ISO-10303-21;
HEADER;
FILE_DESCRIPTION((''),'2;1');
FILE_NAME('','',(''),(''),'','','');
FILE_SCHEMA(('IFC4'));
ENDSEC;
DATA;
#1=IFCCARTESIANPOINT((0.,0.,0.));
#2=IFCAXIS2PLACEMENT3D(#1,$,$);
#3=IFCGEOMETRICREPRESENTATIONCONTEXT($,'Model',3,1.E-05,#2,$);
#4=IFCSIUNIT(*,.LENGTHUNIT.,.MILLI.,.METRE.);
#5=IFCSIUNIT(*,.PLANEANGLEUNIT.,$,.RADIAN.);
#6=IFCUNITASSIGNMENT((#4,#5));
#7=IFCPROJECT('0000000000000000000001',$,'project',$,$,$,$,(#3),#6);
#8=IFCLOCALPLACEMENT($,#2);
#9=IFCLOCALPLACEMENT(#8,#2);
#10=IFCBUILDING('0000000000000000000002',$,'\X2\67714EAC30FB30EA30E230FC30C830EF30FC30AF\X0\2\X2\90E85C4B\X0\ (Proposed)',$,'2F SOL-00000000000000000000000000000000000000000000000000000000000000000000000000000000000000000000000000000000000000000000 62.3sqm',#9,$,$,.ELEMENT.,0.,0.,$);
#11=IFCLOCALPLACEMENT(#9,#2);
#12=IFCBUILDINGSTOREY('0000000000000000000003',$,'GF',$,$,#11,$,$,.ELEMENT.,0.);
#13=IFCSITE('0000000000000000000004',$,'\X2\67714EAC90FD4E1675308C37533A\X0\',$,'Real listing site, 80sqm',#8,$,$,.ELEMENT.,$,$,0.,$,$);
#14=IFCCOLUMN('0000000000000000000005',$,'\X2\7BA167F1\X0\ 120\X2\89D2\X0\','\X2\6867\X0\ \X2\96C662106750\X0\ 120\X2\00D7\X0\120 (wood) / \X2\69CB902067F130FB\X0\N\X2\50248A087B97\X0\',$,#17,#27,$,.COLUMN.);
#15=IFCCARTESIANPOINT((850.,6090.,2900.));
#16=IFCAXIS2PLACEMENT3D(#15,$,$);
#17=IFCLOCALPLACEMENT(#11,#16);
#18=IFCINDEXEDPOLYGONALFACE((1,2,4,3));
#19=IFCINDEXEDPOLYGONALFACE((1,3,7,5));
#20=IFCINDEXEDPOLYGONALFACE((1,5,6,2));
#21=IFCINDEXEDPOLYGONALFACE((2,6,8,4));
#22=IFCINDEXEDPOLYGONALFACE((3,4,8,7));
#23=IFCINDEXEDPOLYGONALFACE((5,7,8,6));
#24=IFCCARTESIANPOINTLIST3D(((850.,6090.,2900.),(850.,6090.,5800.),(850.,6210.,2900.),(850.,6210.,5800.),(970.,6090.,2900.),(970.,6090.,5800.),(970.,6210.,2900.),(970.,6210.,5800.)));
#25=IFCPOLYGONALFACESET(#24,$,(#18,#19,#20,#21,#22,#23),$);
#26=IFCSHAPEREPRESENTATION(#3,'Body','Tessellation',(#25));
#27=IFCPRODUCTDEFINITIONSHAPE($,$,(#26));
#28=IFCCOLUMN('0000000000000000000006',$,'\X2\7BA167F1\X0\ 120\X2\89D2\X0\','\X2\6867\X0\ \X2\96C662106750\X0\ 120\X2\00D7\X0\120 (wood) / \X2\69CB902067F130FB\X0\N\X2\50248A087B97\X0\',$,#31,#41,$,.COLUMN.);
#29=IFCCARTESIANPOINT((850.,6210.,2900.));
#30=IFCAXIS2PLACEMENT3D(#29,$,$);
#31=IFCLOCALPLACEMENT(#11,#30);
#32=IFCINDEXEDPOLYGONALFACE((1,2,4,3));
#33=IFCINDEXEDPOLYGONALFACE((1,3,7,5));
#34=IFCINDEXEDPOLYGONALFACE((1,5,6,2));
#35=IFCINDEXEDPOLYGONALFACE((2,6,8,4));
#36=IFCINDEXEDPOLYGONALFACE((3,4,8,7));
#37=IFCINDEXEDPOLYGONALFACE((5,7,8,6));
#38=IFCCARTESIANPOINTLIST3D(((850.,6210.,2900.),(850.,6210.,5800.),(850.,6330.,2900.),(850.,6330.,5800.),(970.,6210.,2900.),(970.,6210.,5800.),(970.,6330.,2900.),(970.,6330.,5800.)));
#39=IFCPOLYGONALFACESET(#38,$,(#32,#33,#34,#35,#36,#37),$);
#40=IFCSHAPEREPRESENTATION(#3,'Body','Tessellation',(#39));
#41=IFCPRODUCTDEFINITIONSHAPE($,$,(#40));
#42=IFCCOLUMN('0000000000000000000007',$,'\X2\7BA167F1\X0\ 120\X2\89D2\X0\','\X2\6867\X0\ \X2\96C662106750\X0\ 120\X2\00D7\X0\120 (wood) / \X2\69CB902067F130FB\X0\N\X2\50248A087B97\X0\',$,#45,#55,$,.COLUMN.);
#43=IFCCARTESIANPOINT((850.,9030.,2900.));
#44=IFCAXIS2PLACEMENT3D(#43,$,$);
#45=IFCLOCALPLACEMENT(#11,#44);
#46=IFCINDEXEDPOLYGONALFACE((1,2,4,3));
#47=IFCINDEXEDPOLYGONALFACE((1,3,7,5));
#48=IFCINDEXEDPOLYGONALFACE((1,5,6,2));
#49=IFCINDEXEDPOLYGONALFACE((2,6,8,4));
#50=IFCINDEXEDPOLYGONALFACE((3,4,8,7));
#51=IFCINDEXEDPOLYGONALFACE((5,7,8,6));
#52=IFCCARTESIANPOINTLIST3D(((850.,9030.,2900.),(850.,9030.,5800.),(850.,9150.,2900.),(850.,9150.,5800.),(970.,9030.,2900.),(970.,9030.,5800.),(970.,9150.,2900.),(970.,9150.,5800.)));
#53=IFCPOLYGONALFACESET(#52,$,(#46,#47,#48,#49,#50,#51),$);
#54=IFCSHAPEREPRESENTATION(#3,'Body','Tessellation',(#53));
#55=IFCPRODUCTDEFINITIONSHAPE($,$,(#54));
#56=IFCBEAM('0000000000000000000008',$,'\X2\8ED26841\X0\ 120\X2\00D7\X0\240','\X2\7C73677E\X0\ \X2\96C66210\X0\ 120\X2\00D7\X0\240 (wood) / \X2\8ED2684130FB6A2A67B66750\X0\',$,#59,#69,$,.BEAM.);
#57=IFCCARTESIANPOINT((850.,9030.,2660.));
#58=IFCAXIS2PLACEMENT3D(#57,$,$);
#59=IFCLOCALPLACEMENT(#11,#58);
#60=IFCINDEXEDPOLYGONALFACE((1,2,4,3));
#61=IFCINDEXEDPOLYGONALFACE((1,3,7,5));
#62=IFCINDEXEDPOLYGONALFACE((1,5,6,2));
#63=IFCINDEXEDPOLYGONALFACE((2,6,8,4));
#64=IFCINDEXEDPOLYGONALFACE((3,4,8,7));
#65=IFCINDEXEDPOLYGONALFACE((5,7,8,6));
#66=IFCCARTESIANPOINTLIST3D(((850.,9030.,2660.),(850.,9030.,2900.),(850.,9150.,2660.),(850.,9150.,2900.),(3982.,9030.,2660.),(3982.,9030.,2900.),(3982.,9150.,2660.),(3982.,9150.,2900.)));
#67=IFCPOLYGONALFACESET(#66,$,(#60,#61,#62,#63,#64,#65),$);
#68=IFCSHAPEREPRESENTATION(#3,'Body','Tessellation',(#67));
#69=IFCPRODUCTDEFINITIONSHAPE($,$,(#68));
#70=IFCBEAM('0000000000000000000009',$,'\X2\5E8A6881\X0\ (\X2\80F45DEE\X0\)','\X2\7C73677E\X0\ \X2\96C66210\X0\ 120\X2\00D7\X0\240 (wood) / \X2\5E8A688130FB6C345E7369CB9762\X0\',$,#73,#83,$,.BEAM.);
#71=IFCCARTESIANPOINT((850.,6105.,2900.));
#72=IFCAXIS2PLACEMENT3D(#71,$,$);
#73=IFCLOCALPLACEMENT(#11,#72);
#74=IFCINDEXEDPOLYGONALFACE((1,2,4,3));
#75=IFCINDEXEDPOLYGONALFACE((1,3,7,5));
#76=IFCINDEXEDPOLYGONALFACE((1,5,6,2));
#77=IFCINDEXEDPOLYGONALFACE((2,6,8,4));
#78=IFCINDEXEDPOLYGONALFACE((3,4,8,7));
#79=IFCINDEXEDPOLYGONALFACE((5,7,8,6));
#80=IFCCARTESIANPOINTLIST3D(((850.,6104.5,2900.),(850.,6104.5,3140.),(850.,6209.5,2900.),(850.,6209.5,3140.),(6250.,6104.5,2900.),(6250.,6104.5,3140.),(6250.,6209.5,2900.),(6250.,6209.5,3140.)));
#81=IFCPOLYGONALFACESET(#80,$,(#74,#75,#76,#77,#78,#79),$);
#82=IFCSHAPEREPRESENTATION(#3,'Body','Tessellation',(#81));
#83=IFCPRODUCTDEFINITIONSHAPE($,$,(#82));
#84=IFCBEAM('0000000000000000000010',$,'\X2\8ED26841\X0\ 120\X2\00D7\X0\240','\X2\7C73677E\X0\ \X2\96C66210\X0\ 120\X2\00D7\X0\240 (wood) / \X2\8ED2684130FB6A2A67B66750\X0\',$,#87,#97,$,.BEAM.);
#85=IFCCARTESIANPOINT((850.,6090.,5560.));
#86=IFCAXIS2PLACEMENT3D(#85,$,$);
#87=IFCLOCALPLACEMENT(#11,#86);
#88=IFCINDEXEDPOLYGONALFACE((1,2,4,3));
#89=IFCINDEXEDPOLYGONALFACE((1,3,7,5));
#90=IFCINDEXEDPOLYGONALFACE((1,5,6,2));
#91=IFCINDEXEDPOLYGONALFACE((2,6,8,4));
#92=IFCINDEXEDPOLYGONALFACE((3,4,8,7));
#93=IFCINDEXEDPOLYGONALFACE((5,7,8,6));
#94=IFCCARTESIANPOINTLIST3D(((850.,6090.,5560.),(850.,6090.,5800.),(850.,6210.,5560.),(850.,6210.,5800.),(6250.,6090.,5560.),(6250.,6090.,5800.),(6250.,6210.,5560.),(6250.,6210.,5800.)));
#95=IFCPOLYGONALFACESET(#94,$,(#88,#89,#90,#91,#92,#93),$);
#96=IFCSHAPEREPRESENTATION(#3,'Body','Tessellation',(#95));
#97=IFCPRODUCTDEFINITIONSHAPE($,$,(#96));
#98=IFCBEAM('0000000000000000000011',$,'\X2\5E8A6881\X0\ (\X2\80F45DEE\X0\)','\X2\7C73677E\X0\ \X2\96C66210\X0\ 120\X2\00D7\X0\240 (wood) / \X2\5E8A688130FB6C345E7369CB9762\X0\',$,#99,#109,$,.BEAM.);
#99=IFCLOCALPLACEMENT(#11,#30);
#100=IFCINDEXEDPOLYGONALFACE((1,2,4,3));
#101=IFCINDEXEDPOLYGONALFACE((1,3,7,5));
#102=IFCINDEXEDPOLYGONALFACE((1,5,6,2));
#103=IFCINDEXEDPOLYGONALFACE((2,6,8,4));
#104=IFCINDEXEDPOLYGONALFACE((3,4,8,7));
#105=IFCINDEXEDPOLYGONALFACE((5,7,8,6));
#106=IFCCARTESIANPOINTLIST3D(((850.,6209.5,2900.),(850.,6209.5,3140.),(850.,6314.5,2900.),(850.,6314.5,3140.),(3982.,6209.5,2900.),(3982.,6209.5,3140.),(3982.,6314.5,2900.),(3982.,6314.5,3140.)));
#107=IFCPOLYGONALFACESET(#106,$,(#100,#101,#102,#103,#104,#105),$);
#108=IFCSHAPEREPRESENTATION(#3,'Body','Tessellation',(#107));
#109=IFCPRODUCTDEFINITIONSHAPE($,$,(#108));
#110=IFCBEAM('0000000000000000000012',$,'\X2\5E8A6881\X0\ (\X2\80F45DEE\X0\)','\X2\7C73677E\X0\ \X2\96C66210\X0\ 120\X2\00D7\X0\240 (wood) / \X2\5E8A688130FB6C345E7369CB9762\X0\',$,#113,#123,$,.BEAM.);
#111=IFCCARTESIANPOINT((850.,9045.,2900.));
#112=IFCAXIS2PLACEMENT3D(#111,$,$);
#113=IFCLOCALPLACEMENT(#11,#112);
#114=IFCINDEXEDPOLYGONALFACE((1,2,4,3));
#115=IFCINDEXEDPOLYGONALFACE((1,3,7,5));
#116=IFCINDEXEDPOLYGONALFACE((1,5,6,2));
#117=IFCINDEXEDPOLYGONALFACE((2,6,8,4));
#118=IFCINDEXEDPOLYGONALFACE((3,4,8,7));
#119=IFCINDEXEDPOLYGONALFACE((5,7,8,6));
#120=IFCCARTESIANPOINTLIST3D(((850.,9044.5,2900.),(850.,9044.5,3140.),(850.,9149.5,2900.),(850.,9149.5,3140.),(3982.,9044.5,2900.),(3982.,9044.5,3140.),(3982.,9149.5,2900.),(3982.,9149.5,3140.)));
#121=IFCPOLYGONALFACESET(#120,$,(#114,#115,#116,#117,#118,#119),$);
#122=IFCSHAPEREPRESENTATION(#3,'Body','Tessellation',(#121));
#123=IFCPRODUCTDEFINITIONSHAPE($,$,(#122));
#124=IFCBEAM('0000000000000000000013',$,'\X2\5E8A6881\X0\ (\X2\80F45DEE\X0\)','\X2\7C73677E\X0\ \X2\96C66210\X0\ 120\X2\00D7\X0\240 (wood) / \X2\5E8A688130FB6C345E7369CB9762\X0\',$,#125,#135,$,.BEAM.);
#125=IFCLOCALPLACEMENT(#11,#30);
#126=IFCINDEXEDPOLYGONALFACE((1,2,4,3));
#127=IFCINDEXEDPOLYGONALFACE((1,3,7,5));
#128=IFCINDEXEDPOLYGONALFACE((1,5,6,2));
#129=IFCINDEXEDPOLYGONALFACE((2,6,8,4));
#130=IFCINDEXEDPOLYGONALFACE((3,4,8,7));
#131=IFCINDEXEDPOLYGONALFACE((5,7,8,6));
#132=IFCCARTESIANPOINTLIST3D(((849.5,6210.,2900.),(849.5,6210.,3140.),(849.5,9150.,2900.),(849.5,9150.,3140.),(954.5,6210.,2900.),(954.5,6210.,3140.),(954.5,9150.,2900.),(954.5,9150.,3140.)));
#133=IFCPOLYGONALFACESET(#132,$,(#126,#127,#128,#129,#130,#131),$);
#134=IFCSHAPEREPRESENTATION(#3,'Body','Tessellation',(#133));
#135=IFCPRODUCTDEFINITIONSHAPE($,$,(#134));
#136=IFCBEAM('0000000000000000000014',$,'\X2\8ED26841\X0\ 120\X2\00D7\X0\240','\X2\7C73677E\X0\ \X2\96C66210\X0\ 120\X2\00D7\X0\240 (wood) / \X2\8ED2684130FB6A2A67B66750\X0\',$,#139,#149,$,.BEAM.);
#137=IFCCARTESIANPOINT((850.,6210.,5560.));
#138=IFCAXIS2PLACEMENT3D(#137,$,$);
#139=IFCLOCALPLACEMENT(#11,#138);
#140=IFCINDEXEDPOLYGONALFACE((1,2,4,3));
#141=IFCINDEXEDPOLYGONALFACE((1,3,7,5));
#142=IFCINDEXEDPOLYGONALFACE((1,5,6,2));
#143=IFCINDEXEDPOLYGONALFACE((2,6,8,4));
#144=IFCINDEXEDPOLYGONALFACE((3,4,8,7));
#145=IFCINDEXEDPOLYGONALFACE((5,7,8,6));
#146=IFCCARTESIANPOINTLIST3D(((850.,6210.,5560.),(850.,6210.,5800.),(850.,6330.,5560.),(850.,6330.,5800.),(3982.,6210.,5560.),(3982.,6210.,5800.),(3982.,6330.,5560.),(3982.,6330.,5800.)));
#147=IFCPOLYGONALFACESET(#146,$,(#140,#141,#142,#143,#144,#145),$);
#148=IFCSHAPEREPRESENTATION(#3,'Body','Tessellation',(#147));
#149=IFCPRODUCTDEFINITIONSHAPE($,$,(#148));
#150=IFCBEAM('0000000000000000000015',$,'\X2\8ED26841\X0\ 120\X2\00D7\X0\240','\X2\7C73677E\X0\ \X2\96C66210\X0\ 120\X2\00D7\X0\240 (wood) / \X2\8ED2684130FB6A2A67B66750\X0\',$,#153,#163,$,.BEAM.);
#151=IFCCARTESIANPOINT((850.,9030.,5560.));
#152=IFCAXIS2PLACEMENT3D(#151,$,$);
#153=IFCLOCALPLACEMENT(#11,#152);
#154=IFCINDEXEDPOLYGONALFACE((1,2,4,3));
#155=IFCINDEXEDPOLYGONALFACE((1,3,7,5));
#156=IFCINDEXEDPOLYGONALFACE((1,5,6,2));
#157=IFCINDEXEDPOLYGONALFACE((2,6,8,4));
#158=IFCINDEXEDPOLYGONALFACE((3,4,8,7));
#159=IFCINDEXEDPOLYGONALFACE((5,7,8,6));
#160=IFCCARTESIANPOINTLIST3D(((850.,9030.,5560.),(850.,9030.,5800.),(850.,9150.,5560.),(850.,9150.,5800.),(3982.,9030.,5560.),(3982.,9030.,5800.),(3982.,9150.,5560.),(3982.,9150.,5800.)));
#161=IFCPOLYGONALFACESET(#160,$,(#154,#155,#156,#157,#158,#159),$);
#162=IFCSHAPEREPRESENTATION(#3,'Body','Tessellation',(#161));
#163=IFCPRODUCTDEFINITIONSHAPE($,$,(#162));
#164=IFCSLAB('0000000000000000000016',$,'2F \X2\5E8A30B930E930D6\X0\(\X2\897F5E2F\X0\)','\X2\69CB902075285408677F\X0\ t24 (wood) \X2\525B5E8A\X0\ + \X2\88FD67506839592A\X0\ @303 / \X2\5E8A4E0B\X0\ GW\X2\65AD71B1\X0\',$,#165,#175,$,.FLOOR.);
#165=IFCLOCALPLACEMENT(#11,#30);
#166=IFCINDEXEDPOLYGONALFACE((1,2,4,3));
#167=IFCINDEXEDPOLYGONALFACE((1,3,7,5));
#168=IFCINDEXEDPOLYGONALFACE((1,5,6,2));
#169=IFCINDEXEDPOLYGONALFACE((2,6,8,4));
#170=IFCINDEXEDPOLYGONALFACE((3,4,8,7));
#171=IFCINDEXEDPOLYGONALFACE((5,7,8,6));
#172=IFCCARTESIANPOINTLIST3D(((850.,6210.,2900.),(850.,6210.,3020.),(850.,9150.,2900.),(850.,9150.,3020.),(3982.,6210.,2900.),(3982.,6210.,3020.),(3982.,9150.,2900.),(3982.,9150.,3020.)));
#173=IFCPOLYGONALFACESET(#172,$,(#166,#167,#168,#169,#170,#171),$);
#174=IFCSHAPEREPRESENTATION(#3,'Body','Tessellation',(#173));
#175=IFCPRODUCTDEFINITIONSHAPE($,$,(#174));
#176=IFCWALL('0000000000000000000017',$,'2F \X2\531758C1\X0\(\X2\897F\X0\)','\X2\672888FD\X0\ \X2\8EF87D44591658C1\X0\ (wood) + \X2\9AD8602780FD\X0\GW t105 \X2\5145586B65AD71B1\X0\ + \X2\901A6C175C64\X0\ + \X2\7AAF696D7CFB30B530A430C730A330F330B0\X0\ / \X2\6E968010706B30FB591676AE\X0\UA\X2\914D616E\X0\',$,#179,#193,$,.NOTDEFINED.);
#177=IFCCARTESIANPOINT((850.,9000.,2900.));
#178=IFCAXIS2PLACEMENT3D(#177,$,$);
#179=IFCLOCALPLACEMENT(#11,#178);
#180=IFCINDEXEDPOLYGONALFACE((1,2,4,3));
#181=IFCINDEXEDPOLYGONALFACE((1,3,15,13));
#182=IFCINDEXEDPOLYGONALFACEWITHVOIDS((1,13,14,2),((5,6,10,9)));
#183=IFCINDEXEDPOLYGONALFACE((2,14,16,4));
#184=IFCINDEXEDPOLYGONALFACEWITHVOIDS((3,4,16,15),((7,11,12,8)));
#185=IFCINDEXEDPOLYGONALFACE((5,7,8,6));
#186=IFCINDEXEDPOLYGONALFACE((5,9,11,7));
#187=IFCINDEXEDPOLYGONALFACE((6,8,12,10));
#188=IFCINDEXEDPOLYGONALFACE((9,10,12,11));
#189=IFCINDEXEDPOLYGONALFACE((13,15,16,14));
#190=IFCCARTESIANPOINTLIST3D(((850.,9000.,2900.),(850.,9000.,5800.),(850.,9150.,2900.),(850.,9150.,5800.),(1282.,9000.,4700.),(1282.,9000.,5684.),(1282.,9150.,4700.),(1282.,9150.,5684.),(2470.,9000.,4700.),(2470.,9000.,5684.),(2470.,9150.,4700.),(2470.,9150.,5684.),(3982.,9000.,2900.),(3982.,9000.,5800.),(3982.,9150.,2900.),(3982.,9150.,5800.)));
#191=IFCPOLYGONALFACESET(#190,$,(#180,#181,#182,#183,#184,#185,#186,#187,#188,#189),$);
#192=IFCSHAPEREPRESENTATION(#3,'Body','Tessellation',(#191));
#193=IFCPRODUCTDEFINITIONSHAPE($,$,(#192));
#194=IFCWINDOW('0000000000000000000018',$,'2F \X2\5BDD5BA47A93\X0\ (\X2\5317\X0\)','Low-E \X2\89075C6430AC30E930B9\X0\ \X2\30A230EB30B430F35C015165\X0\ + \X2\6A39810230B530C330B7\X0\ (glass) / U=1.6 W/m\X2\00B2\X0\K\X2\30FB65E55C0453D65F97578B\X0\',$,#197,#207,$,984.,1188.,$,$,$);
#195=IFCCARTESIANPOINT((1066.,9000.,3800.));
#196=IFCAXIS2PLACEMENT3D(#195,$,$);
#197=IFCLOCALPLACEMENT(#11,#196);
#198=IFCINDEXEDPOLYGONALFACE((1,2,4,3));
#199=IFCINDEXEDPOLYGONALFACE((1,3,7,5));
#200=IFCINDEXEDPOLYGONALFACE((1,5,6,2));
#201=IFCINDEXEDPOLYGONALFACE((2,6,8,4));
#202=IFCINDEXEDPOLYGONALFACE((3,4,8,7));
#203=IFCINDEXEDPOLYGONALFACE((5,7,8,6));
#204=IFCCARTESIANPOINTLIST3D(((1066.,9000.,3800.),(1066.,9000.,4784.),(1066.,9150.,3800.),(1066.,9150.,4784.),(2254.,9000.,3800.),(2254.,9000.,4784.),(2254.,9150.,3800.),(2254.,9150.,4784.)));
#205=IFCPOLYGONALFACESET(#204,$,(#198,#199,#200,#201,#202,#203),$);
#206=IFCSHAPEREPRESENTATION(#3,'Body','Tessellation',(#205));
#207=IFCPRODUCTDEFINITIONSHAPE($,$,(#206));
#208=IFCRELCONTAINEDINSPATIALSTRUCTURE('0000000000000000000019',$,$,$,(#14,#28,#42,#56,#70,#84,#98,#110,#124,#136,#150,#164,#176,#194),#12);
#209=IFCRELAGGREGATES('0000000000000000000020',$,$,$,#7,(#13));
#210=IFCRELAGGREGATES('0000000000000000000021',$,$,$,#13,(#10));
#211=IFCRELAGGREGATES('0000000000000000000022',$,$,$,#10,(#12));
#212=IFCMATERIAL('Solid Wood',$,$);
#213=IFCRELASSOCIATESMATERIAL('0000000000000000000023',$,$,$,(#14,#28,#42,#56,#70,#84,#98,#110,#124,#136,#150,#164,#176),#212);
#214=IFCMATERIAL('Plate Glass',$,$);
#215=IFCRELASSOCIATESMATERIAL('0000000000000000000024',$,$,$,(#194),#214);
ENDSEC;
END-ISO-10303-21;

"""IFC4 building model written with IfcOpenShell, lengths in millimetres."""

from ifc_helpers import new_model, si_unit, frame, frame_2d, origin, place, context, project, spatial, rectangle, extrude, material, element, fill, save


model = new_model("IFC4")

# Units and contexts
model_context = context("Model", 3, precision=1e-05, world=origin())
ifc_project = project(units=[si_unit("LENGTHUNIT", "METRE", prefix="MILLI"), si_unit("PLANEANGLEUNIT", "RADIAN")], contexts=[model_context])

# Site, building, storey
site_placement = place(None, origin())
site = spatial("IfcSite", under=ifc_project, at=site_placement, Name="東京都世田谷区", ObjectType="Real listing site, 80sqm", CompositionType="ELEMENT", RefElevation=0.0)
building_placement = place(site_placement, origin())
building = spatial("IfcBuilding", under=site, at=building_placement, Name="東京・リモートワーク2部屋 (Proposed)", ObjectType="2F SOL-00000000000000000000000000000000000000000000000000000000000000000000000000000000000000000000000000000000000000000000 62.3sqm", CompositionType="ELEMENT", ElevationOfRefHeight=0.0, ElevationOfTerrain=0.0)
storey_placement = place(building_placement, origin())
storey = spatial("IfcBuildingStorey", under=building, at=storey_placement, Name="GF", CompositionType="ELEMENT", Elevation=0.0)

# Columns
ifc_material_1 = material(Name="Solid Wood")
column_1_placement = place(storey_placement, frame((850.0, 6090.0, 2900.0)))
element("IfcColumn", 1, at=column_1_placement, inside=storey, material=ifc_material_1, Name="管柱 120角", Description="桧 集成材 120×120 (wood) / 構造柱・N値計算", PredefinedType="COLUMN", context=model_context, shape_type="SweptSolid", body=[
    extrude(rectangle(XDim=120.0, YDim=120.0, at=frame_2d((60.0, 60.0))), frame((850.0, 6090.0, 2900.0)), (0.0, 0.0, 1.0), 2900.0),
])
column_2_placement = place(storey_placement, frame((850.0, 6210.0, 2900.0)))
element("IfcColumn", 2, at=column_2_placement, inside=storey, material=ifc_material_1, Name="管柱 120角", Description="桧 集成材 120×120 (wood) / 構造柱・N値計算", PredefinedType="COLUMN", context=model_context, shape_type="SweptSolid", body=[
    extrude(rectangle(XDim=120.0, YDim=120.0, at=frame_2d((60.0, 60.0))), frame((850.0, 6210.0, 2900.0)), (0.0, 0.0, 1.0), 2900.0),
])
column_3_placement = place(storey_placement, frame((850.0, 9030.0, 2900.0)))
element("IfcColumn", 3, at=column_3_placement, inside=storey, material=ifc_material_1, Name="管柱 120角", Description="桧 集成材 120×120 (wood) / 構造柱・N値計算", PredefinedType="COLUMN", context=model_context, shape_type="SweptSolid", body=[
    extrude(rectangle(XDim=120.0, YDim=120.0, at=frame_2d((60.0, 60.0))), frame((850.0, 9030.0, 2900.0)), (0.0, 0.0, 1.0), 2900.0),
])

# Beams
beam_1_placement = place(storey_placement, frame((850.0, 9030.0, 2660.0)))
element("IfcBeam", 4, at=beam_1_placement, inside=storey, material=ifc_material_1, Name="軒桁 120×240", Description="米松 集成 120×240 (wood) / 軒桁・横架材", PredefinedType="BEAM", context=model_context, shape_type="SweptSolid", body=[
    extrude(rectangle(XDim=3132.0, YDim=120.0, at=frame_2d((1566.0, 60.0))), frame((850.0, 9030.0, 2660.0)), (0.0, 0.0, 1.0), 240.0),
])
beam_2_placement = place(storey_placement, frame((850.0, 6105.0, 2900.0)))
element("IfcBeam", 5, at=beam_2_placement, inside=storey, material=ifc_material_1, Name="床梁 (胴差)", Description="米松 集成 120×240 (wood) / 床梁・水平構面", PredefinedType="BEAM", context=model_context, shape_type="SweptSolid", body=[
    extrude(rectangle(XDim=5400.0, YDim=105.0, at=frame_2d((2700.0, 52.0))), frame((850.0, 6105.0, 2900.0)), (0.0, 0.0, 1.0), 240.0),
])
beam_3_placement = place(storey_placement, frame((850.0, 6090.0, 5560.0)))
element("IfcBeam", 6, at=beam_3_placement, inside=storey, material=ifc_material_1, Name="軒桁 120×240", Description="米松 集成 120×240 (wood) / 軒桁・横架材", PredefinedType="BEAM", context=model_context, shape_type="SweptSolid", body=[
    extrude(rectangle(XDim=5400.0, YDim=120.0, at=frame_2d((2700.0, 60.0))), frame((850.0, 6090.0, 5560.0)), (0.0, 0.0, 1.0), 240.0),
])
beam_4_placement = place(storey_placement, frame((850.0, 6210.0, 2900.0)))
element("IfcBeam", 7, at=beam_4_placement, inside=storey, material=ifc_material_1, Name="床梁 (胴差)", Description="米松 集成 120×240 (wood) / 床梁・水平構面", PredefinedType="BEAM", context=model_context, shape_type="SweptSolid", body=[
    extrude(rectangle(XDim=3132.0, YDim=105.0, at=frame_2d((1566.0, 52.0))), frame((850.0, 6210.0, 2900.0)), (0.0, 0.0, 1.0), 240.0),
])
beam_5_placement = place(storey_placement, frame((850.0, 9045.0, 2900.0)))
element("IfcBeam", 8, at=beam_5_placement, inside=storey, material=ifc_material_1, Name="床梁 (胴差)", Description="米松 集成 120×240 (wood) / 床梁・水平構面", PredefinedType="BEAM", context=model_context, shape_type="SweptSolid", body=[
    extrude(rectangle(XDim=3132.0, YDim=105.0, at=frame_2d((1566.0, 52.0))), frame((850.0, 9045.0, 2900.0)), (0.0, 0.0, 1.0), 240.0),
])
beam_6_placement = place(storey_placement, frame((850.0, 6210.0, 2900.0)))
element("IfcBeam", 9, at=beam_6_placement, inside=storey, material=ifc_material_1, Name="床梁 (胴差)", Description="米松 集成 120×240 (wood) / 床梁・水平構面", PredefinedType="BEAM", context=model_context, shape_type="SweptSolid", body=[
    extrude(rectangle(XDim=105.0, YDim=2940.0, at=frame_2d((52.0, 1470.0))), frame((850.0, 6210.0, 2900.0)), (0.0, 0.0, 1.0), 240.0),
])
beam_7_placement = place(storey_placement, frame((850.0, 6210.0, 5560.0)))
element("IfcBeam", 10, at=beam_7_placement, inside=storey, material=ifc_material_1, Name="軒桁 120×240", Description="米松 集成 120×240 (wood) / 軒桁・横架材", PredefinedType="BEAM", context=model_context, shape_type="SweptSolid", body=[
    extrude(rectangle(XDim=3132.0, YDim=120.0, at=frame_2d((1566.0, 60.0))), frame((850.0, 6210.0, 5560.0)), (0.0, 0.0, 1.0), 240.0),
])
beam_8_placement = place(storey_placement, frame((850.0, 9030.0, 5560.0)))
element("IfcBeam", 11, at=beam_8_placement, inside=storey, material=ifc_material_1, Name="軒桁 120×240", Description="米松 集成 120×240 (wood) / 軒桁・横架材", PredefinedType="BEAM", context=model_context, shape_type="SweptSolid", body=[
    extrude(rectangle(XDim=3132.0, YDim=120.0, at=frame_2d((1566.0, 60.0))), frame((850.0, 9030.0, 5560.0)), (0.0, 0.0, 1.0), 240.0),
])

# Slab
slab_placement = place(storey_placement, frame((850.0, 6210.0, 2900.0)))
element("IfcSlab", 12, at=slab_placement, inside=storey, material=ifc_material_1, Name="2F 床スラブ(西帯)", Description="構造用合板 t24 (wood) 剛床 + 製材根太 @303 / 床下 GW断熱", PredefinedType="FLOOR", context=model_context, shape_type="SweptSolid", body=[
    extrude(rectangle(XDim=3132.0, YDim=2940.0, at=frame_2d((1566.0, 1470.0))), frame((850.0, 6210.0, 2900.0)), (0.0, 0.0, 1.0), 120.0),
])

# Wall, opening, window
wall_1_placement = place(storey_placement, frame((850.0, 9000.0, 2900.0)))
wall_1 = element("IfcWall", 13, at=wall_1_placement, inside=storey, material=ifc_material_1, Name="2F 北壁(西)", Description="木製 軸組外壁 (wood) + 高性能GW t105 充填断熱 + 通気層 + 窯業系サイディング / 準耐火・外皮UA配慮", PredefinedType="NOTDEFINED", context=model_context, shape_type="SweptSolid", body=[
    extrude(rectangle(XDim=3132.0, YDim=150.0, at=frame_2d((1566.0, 75.0))), frame((850.0, 9000.0, 2900.0)), (0.0, 0.0, 1.0), 2900.0),
])
opening_placement = place(storey_placement, frame((1066.0, 9000.0, 3800.0)))
opening = element("IfcOpeningElement", 14, at=opening_placement, cuts=wall_1, PredefinedType="NOTDEFINED", context=model_context, shape_type="SweptSolid", body=[
    extrude(rectangle(XDim=1188.0, YDim=150.0, at=frame_2d((594.0, 75.0))), frame((1066.0, 9000.0, 3800.0)), (0.0, 0.0, 1.0), 984.0),
])
ifc_material_2 = material(Name="Plate Glass")
window_placement = place(storey_placement, frame((1066.0, 9000.0, 3800.0)))
window = element("IfcWindow", 15, at=window_placement, inside=storey, material=ifc_material_2, Name="2F 寝室窓 (北)", Description="Low-E 複層ガラス アルゴン封入 + 樹脂サッシ (glass) / U=1.6 W/m²K・日射取得型", OverallHeight=984.0, OverallWidth=1188.0, context=model_context, shape_type="SweptSolid", body=[
    extrude(rectangle(XDim=1188.0, YDim=150.0, at=frame_2d((594.0, 75.0))), frame((1066.0, 9000.0, 3800.0)), (0.0, 0.0, 1.0), 984.0),
])
fill(opening, window)

save(model, "model.ifc")
